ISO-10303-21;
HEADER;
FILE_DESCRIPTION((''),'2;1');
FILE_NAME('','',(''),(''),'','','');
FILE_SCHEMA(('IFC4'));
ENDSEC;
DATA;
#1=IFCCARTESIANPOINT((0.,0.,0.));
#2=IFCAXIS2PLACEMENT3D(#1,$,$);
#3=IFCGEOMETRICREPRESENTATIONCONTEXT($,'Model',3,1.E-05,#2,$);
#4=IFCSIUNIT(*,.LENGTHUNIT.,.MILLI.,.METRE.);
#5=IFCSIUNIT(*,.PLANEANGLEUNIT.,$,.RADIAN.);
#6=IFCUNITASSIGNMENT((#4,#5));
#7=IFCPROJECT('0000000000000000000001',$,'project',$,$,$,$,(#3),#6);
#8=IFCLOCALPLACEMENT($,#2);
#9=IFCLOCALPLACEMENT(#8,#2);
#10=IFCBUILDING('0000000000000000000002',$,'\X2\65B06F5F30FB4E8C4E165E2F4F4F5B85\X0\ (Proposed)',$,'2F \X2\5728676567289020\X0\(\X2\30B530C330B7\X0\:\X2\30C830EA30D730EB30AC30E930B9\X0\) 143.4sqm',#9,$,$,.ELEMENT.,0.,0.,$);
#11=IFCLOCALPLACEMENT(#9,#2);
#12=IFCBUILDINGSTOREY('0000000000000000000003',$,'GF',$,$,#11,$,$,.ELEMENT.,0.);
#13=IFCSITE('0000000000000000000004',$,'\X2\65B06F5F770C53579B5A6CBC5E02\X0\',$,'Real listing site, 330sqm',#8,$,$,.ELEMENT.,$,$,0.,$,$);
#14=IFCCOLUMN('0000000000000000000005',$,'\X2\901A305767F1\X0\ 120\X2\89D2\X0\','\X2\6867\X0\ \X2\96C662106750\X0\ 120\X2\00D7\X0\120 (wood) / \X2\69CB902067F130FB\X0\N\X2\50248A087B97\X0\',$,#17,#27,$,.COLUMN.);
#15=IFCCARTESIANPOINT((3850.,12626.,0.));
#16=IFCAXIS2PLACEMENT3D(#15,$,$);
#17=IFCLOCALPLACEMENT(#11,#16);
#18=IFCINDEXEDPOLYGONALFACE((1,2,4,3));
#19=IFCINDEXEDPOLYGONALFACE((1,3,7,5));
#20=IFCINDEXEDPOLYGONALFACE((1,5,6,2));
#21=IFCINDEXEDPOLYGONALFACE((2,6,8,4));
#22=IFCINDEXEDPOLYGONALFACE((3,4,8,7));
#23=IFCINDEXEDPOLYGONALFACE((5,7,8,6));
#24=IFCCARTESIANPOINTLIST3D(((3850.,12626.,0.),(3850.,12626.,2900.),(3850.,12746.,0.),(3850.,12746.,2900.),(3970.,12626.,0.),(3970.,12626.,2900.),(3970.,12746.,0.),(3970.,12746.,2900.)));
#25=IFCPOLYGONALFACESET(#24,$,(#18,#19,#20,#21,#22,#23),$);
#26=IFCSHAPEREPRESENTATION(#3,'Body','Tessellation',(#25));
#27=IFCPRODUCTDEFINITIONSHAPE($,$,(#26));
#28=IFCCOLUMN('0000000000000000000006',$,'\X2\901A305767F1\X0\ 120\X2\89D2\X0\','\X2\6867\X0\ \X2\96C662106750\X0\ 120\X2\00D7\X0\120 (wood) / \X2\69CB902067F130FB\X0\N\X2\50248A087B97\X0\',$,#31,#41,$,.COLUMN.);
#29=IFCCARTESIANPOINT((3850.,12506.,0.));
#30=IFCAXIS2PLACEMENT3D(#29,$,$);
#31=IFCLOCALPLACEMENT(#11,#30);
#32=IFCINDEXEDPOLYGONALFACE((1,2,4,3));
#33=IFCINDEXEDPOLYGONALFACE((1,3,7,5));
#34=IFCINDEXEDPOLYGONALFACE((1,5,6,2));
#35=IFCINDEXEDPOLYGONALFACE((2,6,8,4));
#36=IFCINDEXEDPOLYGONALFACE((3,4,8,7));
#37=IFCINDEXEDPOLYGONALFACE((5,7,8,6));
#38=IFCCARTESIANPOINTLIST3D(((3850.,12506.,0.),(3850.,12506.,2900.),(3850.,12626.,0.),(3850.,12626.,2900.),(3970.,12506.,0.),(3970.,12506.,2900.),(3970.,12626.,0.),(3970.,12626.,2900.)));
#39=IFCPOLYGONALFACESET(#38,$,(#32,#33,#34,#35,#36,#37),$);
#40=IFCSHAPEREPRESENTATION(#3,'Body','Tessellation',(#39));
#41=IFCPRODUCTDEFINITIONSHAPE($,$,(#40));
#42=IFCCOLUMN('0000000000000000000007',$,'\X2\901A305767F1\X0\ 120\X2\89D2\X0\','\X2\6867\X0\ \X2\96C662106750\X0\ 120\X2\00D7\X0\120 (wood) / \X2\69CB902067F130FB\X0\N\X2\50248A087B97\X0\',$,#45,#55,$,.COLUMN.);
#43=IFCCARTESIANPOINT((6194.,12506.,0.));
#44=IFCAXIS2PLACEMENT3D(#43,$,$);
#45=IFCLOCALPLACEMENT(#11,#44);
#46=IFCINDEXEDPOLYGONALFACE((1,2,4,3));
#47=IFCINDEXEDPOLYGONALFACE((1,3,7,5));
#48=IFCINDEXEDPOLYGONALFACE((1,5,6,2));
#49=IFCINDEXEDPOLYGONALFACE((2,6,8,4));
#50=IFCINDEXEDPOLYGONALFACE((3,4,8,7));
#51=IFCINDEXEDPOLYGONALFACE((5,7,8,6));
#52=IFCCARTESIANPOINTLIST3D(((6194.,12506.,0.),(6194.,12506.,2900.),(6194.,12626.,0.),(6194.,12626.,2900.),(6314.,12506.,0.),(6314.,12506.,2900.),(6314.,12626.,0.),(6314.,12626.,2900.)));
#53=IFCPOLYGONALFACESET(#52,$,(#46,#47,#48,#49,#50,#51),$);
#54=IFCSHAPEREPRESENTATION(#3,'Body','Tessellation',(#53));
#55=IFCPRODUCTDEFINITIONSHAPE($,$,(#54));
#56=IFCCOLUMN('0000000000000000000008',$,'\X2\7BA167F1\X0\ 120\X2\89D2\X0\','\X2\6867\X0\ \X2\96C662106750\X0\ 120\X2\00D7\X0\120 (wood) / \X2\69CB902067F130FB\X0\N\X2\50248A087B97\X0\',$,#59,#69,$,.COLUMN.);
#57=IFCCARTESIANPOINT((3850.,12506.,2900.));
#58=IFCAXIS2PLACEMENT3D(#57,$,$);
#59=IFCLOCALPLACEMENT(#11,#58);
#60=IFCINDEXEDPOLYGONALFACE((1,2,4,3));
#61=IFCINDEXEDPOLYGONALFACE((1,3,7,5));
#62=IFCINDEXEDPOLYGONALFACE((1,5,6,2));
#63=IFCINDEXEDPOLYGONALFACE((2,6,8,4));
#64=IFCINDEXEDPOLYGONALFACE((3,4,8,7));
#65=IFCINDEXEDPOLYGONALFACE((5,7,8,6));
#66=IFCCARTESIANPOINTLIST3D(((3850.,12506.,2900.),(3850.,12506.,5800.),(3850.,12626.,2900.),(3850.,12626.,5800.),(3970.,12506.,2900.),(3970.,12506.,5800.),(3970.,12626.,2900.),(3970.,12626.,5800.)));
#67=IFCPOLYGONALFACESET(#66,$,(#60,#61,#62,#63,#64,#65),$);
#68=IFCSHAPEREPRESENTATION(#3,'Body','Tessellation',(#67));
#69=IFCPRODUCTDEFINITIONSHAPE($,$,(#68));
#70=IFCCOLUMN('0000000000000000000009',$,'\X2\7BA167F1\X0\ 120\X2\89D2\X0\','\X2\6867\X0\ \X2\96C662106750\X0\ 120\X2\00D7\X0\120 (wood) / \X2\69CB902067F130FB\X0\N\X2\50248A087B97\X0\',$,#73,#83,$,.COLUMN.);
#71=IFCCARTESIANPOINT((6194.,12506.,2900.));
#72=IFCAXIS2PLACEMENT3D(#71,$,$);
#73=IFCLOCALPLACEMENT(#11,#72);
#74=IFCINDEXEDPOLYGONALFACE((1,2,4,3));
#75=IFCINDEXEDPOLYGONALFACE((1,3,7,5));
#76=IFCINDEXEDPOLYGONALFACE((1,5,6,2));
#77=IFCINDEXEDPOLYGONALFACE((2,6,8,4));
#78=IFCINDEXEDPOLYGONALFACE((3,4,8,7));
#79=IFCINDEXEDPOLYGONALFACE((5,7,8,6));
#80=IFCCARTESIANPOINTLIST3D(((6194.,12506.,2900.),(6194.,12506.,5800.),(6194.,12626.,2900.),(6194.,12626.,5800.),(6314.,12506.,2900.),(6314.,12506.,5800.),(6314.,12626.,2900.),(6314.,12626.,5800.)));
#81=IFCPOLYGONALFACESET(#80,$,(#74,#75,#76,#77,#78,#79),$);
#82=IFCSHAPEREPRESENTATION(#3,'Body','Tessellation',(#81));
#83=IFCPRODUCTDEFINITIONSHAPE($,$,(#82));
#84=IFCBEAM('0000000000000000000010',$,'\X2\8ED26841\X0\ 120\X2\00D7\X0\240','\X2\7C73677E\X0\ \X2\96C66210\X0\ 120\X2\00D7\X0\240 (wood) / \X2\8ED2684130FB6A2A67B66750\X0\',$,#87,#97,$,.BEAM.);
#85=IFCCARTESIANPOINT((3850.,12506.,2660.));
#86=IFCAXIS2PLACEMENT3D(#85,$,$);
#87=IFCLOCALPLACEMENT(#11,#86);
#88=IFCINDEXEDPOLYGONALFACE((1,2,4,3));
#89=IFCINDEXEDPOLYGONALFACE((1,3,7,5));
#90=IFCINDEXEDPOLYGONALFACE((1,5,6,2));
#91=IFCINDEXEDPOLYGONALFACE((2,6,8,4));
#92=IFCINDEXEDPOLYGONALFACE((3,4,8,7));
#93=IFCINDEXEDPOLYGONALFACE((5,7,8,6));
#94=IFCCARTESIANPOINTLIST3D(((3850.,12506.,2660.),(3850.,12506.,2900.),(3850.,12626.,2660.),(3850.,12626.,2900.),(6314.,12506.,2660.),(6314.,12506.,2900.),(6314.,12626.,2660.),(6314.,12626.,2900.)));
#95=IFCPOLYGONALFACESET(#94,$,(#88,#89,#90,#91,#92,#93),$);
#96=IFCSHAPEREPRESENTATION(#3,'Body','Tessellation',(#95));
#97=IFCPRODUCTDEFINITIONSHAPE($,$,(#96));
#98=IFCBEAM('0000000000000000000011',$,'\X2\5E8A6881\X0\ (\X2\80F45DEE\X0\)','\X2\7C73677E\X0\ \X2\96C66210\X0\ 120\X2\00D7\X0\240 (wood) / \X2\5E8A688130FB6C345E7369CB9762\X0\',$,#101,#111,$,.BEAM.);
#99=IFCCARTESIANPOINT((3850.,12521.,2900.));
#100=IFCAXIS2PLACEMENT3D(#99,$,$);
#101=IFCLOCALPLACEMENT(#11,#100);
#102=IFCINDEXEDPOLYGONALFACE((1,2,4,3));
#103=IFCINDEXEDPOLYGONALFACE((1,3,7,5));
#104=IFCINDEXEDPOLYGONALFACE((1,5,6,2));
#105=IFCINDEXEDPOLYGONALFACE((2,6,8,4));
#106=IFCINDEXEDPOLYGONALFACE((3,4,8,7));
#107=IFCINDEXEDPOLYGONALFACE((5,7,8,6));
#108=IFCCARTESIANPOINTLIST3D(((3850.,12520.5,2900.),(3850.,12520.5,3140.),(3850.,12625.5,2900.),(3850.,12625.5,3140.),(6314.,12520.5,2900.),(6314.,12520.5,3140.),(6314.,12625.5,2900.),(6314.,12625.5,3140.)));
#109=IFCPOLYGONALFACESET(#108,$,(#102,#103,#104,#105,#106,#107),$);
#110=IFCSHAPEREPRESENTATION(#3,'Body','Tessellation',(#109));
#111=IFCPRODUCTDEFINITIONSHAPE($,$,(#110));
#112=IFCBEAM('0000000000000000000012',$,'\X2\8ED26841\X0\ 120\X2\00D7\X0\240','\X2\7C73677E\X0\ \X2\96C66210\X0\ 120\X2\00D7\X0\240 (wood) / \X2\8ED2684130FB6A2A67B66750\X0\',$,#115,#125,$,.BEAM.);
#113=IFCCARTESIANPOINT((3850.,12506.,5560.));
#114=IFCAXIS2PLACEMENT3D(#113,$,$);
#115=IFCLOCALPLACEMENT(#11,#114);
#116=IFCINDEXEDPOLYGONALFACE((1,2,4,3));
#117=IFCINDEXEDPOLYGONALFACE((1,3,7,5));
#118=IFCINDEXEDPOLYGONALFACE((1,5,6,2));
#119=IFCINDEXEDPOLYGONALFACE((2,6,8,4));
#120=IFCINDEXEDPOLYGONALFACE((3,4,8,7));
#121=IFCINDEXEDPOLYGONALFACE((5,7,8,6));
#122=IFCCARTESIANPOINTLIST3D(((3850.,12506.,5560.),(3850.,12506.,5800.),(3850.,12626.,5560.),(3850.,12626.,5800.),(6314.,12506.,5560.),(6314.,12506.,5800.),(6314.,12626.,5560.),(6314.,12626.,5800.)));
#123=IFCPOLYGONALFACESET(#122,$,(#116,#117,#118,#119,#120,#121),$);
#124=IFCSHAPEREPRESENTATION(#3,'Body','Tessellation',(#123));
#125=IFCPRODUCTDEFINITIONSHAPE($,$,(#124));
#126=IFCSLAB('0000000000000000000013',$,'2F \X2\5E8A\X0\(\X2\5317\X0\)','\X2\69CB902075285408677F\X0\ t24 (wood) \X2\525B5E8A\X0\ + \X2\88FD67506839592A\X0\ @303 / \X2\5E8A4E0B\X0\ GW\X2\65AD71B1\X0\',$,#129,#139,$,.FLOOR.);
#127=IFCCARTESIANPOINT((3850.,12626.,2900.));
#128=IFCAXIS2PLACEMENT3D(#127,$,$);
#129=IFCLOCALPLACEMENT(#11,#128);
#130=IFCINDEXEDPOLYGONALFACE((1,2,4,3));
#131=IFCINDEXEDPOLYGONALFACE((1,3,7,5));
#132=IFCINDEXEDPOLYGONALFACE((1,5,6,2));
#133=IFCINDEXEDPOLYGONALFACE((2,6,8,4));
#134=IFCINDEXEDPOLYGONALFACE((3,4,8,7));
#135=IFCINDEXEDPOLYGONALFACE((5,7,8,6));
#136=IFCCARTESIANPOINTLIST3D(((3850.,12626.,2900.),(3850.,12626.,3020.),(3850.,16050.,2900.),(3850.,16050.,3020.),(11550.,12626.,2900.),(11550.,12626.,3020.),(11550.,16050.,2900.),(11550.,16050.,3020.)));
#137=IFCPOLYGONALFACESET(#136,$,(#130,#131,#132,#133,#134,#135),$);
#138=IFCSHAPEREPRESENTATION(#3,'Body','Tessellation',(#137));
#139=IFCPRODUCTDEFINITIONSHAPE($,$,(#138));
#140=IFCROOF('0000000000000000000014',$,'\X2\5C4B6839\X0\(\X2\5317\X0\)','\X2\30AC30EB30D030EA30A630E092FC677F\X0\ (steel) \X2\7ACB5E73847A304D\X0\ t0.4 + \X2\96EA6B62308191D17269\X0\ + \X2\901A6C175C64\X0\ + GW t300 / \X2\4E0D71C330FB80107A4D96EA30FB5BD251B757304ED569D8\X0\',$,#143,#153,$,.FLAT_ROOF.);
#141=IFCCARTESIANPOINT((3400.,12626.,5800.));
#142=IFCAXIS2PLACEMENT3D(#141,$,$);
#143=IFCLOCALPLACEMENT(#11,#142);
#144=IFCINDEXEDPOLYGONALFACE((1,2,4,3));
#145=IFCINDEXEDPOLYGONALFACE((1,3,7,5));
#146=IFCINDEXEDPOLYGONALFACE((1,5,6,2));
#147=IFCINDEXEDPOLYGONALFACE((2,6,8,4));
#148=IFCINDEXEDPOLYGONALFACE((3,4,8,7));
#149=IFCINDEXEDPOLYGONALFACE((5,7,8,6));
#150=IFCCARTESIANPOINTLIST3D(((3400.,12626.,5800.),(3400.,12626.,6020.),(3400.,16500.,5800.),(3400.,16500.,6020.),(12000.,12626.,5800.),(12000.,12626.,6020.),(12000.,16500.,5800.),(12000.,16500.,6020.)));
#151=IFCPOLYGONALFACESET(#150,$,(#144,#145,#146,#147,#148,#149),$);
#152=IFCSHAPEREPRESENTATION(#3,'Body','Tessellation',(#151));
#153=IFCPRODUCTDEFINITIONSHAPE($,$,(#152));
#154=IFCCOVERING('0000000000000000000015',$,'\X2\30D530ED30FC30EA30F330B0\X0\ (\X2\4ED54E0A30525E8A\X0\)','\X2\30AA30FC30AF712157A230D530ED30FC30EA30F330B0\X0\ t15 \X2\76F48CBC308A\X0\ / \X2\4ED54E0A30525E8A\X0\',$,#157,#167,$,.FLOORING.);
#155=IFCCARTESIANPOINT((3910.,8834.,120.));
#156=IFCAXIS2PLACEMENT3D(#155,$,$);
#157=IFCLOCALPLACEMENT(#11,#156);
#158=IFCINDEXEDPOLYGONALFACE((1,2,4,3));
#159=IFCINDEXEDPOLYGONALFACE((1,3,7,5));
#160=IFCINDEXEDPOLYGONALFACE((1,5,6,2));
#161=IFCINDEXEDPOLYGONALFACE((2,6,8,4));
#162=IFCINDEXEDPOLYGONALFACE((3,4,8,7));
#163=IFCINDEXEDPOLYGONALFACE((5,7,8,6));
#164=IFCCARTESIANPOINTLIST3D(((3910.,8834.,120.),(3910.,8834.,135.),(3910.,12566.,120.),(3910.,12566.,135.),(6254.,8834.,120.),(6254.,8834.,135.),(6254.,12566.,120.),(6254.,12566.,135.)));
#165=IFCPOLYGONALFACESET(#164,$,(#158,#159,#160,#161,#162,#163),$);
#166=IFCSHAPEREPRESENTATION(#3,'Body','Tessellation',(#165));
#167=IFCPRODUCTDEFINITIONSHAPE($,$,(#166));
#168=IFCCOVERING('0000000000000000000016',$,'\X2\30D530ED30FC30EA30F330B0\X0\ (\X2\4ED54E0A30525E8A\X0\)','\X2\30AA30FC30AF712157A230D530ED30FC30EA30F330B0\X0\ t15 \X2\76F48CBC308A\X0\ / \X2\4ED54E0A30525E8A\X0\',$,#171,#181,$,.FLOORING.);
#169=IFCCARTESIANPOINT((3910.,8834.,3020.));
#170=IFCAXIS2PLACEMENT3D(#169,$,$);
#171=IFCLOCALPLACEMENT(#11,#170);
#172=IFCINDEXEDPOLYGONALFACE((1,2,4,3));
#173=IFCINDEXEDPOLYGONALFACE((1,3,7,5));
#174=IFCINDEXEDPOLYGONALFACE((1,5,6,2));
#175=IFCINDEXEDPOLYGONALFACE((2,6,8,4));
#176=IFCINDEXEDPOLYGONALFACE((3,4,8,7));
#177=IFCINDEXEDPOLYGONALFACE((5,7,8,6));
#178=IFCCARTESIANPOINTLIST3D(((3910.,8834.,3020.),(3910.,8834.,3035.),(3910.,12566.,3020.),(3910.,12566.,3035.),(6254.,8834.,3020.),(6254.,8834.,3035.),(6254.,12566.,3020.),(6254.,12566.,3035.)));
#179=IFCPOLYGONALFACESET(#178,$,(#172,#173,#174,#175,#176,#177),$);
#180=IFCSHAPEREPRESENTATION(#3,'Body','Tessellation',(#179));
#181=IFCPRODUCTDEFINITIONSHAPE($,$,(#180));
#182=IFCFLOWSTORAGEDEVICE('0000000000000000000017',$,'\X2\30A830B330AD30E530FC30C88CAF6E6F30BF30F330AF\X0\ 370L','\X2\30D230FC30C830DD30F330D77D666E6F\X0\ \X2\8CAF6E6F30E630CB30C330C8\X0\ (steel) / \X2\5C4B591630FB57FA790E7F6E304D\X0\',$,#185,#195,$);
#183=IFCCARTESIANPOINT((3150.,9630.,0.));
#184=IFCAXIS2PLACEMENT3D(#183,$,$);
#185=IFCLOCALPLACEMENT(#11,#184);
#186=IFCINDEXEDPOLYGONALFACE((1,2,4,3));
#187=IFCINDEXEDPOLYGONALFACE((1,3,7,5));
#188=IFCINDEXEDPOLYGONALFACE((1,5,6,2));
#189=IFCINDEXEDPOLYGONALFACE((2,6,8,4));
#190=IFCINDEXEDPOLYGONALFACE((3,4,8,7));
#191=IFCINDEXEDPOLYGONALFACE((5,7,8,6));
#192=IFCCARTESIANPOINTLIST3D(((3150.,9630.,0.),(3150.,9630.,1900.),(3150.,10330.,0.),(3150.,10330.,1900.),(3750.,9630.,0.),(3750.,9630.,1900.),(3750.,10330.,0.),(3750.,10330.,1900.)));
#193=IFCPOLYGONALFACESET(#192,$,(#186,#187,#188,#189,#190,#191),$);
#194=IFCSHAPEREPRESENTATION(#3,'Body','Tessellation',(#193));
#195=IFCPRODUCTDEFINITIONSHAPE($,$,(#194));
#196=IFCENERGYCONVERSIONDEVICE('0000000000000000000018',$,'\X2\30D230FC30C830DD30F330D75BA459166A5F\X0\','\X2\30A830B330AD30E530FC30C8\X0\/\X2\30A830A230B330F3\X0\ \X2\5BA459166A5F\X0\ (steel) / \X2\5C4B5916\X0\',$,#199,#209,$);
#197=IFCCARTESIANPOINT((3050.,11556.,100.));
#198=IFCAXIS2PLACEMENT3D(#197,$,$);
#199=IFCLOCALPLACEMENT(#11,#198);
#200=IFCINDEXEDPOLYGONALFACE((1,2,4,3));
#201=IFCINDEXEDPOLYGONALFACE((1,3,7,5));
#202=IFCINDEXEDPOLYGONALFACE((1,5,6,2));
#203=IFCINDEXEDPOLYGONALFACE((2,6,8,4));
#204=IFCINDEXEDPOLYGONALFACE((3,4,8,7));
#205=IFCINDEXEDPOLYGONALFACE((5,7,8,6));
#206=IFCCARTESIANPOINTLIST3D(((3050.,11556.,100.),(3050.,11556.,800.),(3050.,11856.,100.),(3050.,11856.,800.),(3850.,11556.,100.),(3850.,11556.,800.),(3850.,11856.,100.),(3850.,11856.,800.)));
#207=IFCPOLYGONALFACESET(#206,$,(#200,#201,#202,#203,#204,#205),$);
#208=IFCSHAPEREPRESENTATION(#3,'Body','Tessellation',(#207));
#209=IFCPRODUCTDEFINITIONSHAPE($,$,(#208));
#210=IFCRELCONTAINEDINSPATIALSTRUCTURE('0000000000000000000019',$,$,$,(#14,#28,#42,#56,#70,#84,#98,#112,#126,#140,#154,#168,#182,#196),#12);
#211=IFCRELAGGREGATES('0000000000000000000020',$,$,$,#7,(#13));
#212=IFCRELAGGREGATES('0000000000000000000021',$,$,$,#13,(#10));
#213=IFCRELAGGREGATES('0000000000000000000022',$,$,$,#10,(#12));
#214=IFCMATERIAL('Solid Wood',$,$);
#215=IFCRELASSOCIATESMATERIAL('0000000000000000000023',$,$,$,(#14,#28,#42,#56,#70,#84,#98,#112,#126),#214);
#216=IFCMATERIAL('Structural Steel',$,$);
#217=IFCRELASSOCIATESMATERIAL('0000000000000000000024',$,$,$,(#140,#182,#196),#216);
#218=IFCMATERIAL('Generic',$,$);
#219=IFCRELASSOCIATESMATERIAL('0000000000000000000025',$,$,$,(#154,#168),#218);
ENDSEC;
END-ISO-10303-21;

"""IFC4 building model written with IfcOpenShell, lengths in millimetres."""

from ifc_helpers import new_model, si_unit, frame, frame_2d, origin, place, context, project, spatial, rectangle, extrude, material, element, save


model = new_model("IFC4")

# Units and contexts
model_context = context("Model", 3, precision=1e-05, world=origin())
ifc_project = project(units=[si_unit("LENGTHUNIT", "METRE", prefix="MILLI"), si_unit("PLANEANGLEUNIT", "RADIAN")], contexts=[model_context])

# Site, building, storey
site_placement = place(None, origin())
site = spatial("IfcSite", under=ifc_project, at=site_placement, Name="新潟県南魚沼市", ObjectType="Real listing site, 330sqm", CompositionType="ELEMENT", RefElevation=0.0)
building_placement = place(site_placement, origin())
building = spatial("IfcBuilding", under=site, at=building_placement, Name="新潟・二世帯住宅 (Proposed)", ObjectType="2F 在来木造(サッシ:トリプルガラス) 143.4sqm", CompositionType="ELEMENT", ElevationOfRefHeight=0.0, ElevationOfTerrain=0.0)
storey_placement = place(building_placement, origin())
storey = spatial("IfcBuildingStorey", under=building, at=storey_placement, Name="GF", CompositionType="ELEMENT", Elevation=0.0)

# Columns
ifc_material_1 = material(Name="Solid Wood")
column_1_placement = place(storey_placement, frame((3850.0, 12626.0, 0.0)))
element("IfcColumn", 1, at=column_1_placement, inside=storey, material=ifc_material_1, Name="通し柱 120角", Description="桧 集成材 120×120 (wood) / 構造柱・N値計算", PredefinedType="COLUMN", context=model_context, shape_type="SweptSolid", body=[
    extrude(rectangle(XDim=120.0, YDim=120.0, at=frame_2d((60.0, 60.0))), frame((3850.0, 12626.0, 0.0)), (0.0, 0.0, 1.0), 2900.0),
])
column_2_placement = place(storey_placement, frame((3850.0, 12506.0, 0.0)))
element("IfcColumn", 2, at=column_2_placement, inside=storey, material=ifc_material_1, Name="通し柱 120角", Description="桧 集成材 120×120 (wood) / 構造柱・N値計算", PredefinedType="COLUMN", context=model_context, shape_type="SweptSolid", body=[
    extrude(rectangle(XDim=120.0, YDim=120.0, at=frame_2d((60.0, 60.0))), frame((3850.0, 12506.0, 0.0)), (0.0, 0.0, 1.0), 2900.0),
])
column_3_placement = place(storey_placement, frame((6194.0, 12506.0, 0.0)))
element("IfcColumn", 3, at=column_3_placement, inside=storey, material=ifc_material_1, Name="通し柱 120角", Description="桧 集成材 120×120 (wood) / 構造柱・N値計算", PredefinedType="COLUMN", context=model_context, shape_type="SweptSolid", body=[
    extrude(rectangle(XDim=120.0, YDim=120.0, at=frame_2d((60.0, 60.0))), frame((6194.0, 12506.0, 0.0)), (0.0, 0.0, 1.0), 2900.0),
])
column_4_placement = place(storey_placement, frame((3850.0, 12506.0, 2900.0)))
element("IfcColumn", 4, at=column_4_placement, inside=storey, material=ifc_material_1, Name="管柱 120角", Description="桧 集成材 120×120 (wood) / 構造柱・N値計算", PredefinedType="COLUMN", context=model_context, shape_type="SweptSolid", body=[
    extrude(rectangle(XDim=120.0, YDim=120.0, at=frame_2d((60.0, 60.0))), frame((3850.0, 12506.0, 2900.0)), (0.0, 0.0, 1.0), 2900.0),
])
column_5_placement = place(storey_placement, frame((6194.0, 12506.0, 2900.0)))
element("IfcColumn", 5, at=column_5_placement, inside=storey, material=ifc_material_1, Name="管柱 120角", Description="桧 集成材 120×120 (wood) / 構造柱・N値計算", PredefinedType="COLUMN", context=model_context, shape_type="SweptSolid", body=[
    extrude(rectangle(XDim=120.0, YDim=120.0, at=frame_2d((60.0, 60.0))), frame((6194.0, 12506.0, 2900.0)), (0.0, 0.0, 1.0), 2900.0),
])

# Beams
beam_1_placement = place(storey_placement, frame((3850.0, 12506.0, 2660.0)))
element("IfcBeam", 6, at=beam_1_placement, inside=storey, material=ifc_material_1, Name="軒桁 120×240", Description="米松 集成 120×240 (wood) / 軒桁・横架材", PredefinedType="BEAM", context=model_context, shape_type="SweptSolid", body=[
    extrude(rectangle(XDim=2464.0, YDim=120.0, at=frame_2d((1232.0, 60.0))), frame((3850.0, 12506.0, 2660.0)), (0.0, 0.0, 1.0), 240.0),
])
beam_2_placement = place(storey_placement, frame((3850.0, 12521.0, 2900.0)))
element("IfcBeam", 7, at=beam_2_placement, inside=storey, material=ifc_material_1, Name="床梁 (胴差)", Description="米松 集成 120×240 (wood) / 床梁・水平構面", PredefinedType="BEAM", context=model_context, shape_type="SweptSolid", body=[
    extrude(rectangle(XDim=2464.0, YDim=105.0, at=frame_2d((1232.0, 52.0))), frame((3850.0, 12521.0, 2900.0)), (0.0, 0.0, 1.0), 240.0),
])
beam_3_placement = place(storey_placement, frame((3850.0, 12506.0, 5560.0)))
element("IfcBeam", 8, at=beam_3_placement, inside=storey, material=ifc_material_1, Name="軒桁 120×240", Description="米松 集成 120×240 (wood) / 軒桁・横架材", PredefinedType="BEAM", context=model_context, shape_type="SweptSolid", body=[
    extrude(rectangle(XDim=2464.0, YDim=120.0, at=frame_2d((1232.0, 60.0))), frame((3850.0, 12506.0, 5560.0)), (0.0, 0.0, 1.0), 240.0),
])

# Slab
slab_1_placement = place(storey_placement, frame((3850.0, 12626.0, 2900.0)))
element("IfcSlab", 9, at=slab_1_placement, inside=storey, material=ifc_material_1, Name="2F 床(北)", Description="構造用合板 t24 (wood) 剛床 + 製材根太 @303 / 床下 GW断熱", PredefinedType="FLOOR", context=model_context, shape_type="SweptSolid", body=[
    extrude(rectangle(XDim=7700.0, YDim=3424.0, at=frame_2d((3850.0, 1712.0))), frame((3850.0, 12626.0, 2900.0)), (0.0, 0.0, 1.0), 120.0),
])

# Roof
ifc_material_2 = material(Name="Structural Steel")
for number, where, name in (
    (10, (3400.0, 12626.0, 5800.0), "屋根(北)"),
):
    element("IfcRoof", number, at=place(storey_placement, frame(where)), inside=storey, material=ifc_material_2, Name=name, Description="ガルバリウム鋼板 (steel) 立平葺き t0.4 + 雪止め金物 + 通気層 + GW t300 / 不燃・耐積雪・寒冷地仕様", PredefinedType="FLAT_ROOF", context=model_context, shape_type="SweptSolid", body=[
        extrude(rectangle(XDim=8600.0, YDim=3874.0, at=frame_2d((4300.0, 1937.0))), frame((3400.0, 12626.0, 5800.0)), (0.0, 0.0, 1.0), 220.0),
    ])

# Coverings
ifc_material_3 = material(Name="Generic")
covering_1_placement = place(storey_placement, frame((3910.0, 8834.0, 120.0)))
element("IfcCovering", 11, at=covering_1_placement, inside=storey, material=ifc_material_3, Name="フローリング (仕上げ床)", Description="オーク無垢フローリング t15 直貼り / 仕上げ床", PredefinedType="FLOORING", context=model_context, shape_type="SweptSolid", body=[
    extrude(rectangle(XDim=2344.0, YDim=3732.0, at=frame_2d((1172.0, 1866.0))), frame((3910.0, 8834.0, 120.0)), (0.0, 0.0, 1.0), 15.0),
])
covering_2_placement = place(storey_placement, frame((3910.0, 8834.0, 3020.0)))
element("IfcCovering", 12, at=covering_2_placement, inside=storey, material=ifc_material_3, Name="フローリング (仕上げ床)", Description="オーク無垢フローリング t15 直貼り / 仕上げ床", PredefinedType="FLOORING", context=model_context, shape_type="SweptSolid", body=[
    extrude(rectangle(XDim=2344.0, YDim=3732.0, at=frame_2d((1172.0, 1866.0))), frame((3910.0, 8834.0, 3020.0)), (0.0, 0.0, 1.0), 15.0),
])

# Flow storage device
flow_storage_device_placement = place(storey_placement, frame((3150.0, 9630.0, 0.0)))
element("IfcFlowStorageDevice", 13, at=flow_storage_device_placement, inside=storey, material=ifc_material_2, Name="エコキュート貯湯タンク 370L", Description="ヒートポンプ給湯 貯湯ユニット (steel) / 屋外・基礎置き", context=model_context, shape_type="SweptSolid", body=[
    extrude(rectangle(XDim=600.0, YDim=700.0, at=frame_2d((300.0, 350.0))), frame((3150.0, 9630.0, 0.0)), (0.0, 0.0, 1.0), 1900.0),
])

# Energy conversion device
energy_conversion_device_placement = place(storey_placement, frame((3050.0, 11556.0, 100.0)))
element("IfcEnergyConversionDevice", 14, at=energy_conversion_device_placement, inside=storey, material=ifc_material_2, Name="ヒートポンプ室外機", Description="エコキュート/エアコン 室外機 (steel) / 屋外", context=model_context, shape_type="SweptSolid", body=[
    extrude(rectangle(XDim=800.0, YDim=300.0, at=frame_2d((400.0, 150.0))), frame((3050.0, 11556.0, 100.0)), (0.0, 0.0, 1.0), 700.0),
])

save(model, "model.ifc")
